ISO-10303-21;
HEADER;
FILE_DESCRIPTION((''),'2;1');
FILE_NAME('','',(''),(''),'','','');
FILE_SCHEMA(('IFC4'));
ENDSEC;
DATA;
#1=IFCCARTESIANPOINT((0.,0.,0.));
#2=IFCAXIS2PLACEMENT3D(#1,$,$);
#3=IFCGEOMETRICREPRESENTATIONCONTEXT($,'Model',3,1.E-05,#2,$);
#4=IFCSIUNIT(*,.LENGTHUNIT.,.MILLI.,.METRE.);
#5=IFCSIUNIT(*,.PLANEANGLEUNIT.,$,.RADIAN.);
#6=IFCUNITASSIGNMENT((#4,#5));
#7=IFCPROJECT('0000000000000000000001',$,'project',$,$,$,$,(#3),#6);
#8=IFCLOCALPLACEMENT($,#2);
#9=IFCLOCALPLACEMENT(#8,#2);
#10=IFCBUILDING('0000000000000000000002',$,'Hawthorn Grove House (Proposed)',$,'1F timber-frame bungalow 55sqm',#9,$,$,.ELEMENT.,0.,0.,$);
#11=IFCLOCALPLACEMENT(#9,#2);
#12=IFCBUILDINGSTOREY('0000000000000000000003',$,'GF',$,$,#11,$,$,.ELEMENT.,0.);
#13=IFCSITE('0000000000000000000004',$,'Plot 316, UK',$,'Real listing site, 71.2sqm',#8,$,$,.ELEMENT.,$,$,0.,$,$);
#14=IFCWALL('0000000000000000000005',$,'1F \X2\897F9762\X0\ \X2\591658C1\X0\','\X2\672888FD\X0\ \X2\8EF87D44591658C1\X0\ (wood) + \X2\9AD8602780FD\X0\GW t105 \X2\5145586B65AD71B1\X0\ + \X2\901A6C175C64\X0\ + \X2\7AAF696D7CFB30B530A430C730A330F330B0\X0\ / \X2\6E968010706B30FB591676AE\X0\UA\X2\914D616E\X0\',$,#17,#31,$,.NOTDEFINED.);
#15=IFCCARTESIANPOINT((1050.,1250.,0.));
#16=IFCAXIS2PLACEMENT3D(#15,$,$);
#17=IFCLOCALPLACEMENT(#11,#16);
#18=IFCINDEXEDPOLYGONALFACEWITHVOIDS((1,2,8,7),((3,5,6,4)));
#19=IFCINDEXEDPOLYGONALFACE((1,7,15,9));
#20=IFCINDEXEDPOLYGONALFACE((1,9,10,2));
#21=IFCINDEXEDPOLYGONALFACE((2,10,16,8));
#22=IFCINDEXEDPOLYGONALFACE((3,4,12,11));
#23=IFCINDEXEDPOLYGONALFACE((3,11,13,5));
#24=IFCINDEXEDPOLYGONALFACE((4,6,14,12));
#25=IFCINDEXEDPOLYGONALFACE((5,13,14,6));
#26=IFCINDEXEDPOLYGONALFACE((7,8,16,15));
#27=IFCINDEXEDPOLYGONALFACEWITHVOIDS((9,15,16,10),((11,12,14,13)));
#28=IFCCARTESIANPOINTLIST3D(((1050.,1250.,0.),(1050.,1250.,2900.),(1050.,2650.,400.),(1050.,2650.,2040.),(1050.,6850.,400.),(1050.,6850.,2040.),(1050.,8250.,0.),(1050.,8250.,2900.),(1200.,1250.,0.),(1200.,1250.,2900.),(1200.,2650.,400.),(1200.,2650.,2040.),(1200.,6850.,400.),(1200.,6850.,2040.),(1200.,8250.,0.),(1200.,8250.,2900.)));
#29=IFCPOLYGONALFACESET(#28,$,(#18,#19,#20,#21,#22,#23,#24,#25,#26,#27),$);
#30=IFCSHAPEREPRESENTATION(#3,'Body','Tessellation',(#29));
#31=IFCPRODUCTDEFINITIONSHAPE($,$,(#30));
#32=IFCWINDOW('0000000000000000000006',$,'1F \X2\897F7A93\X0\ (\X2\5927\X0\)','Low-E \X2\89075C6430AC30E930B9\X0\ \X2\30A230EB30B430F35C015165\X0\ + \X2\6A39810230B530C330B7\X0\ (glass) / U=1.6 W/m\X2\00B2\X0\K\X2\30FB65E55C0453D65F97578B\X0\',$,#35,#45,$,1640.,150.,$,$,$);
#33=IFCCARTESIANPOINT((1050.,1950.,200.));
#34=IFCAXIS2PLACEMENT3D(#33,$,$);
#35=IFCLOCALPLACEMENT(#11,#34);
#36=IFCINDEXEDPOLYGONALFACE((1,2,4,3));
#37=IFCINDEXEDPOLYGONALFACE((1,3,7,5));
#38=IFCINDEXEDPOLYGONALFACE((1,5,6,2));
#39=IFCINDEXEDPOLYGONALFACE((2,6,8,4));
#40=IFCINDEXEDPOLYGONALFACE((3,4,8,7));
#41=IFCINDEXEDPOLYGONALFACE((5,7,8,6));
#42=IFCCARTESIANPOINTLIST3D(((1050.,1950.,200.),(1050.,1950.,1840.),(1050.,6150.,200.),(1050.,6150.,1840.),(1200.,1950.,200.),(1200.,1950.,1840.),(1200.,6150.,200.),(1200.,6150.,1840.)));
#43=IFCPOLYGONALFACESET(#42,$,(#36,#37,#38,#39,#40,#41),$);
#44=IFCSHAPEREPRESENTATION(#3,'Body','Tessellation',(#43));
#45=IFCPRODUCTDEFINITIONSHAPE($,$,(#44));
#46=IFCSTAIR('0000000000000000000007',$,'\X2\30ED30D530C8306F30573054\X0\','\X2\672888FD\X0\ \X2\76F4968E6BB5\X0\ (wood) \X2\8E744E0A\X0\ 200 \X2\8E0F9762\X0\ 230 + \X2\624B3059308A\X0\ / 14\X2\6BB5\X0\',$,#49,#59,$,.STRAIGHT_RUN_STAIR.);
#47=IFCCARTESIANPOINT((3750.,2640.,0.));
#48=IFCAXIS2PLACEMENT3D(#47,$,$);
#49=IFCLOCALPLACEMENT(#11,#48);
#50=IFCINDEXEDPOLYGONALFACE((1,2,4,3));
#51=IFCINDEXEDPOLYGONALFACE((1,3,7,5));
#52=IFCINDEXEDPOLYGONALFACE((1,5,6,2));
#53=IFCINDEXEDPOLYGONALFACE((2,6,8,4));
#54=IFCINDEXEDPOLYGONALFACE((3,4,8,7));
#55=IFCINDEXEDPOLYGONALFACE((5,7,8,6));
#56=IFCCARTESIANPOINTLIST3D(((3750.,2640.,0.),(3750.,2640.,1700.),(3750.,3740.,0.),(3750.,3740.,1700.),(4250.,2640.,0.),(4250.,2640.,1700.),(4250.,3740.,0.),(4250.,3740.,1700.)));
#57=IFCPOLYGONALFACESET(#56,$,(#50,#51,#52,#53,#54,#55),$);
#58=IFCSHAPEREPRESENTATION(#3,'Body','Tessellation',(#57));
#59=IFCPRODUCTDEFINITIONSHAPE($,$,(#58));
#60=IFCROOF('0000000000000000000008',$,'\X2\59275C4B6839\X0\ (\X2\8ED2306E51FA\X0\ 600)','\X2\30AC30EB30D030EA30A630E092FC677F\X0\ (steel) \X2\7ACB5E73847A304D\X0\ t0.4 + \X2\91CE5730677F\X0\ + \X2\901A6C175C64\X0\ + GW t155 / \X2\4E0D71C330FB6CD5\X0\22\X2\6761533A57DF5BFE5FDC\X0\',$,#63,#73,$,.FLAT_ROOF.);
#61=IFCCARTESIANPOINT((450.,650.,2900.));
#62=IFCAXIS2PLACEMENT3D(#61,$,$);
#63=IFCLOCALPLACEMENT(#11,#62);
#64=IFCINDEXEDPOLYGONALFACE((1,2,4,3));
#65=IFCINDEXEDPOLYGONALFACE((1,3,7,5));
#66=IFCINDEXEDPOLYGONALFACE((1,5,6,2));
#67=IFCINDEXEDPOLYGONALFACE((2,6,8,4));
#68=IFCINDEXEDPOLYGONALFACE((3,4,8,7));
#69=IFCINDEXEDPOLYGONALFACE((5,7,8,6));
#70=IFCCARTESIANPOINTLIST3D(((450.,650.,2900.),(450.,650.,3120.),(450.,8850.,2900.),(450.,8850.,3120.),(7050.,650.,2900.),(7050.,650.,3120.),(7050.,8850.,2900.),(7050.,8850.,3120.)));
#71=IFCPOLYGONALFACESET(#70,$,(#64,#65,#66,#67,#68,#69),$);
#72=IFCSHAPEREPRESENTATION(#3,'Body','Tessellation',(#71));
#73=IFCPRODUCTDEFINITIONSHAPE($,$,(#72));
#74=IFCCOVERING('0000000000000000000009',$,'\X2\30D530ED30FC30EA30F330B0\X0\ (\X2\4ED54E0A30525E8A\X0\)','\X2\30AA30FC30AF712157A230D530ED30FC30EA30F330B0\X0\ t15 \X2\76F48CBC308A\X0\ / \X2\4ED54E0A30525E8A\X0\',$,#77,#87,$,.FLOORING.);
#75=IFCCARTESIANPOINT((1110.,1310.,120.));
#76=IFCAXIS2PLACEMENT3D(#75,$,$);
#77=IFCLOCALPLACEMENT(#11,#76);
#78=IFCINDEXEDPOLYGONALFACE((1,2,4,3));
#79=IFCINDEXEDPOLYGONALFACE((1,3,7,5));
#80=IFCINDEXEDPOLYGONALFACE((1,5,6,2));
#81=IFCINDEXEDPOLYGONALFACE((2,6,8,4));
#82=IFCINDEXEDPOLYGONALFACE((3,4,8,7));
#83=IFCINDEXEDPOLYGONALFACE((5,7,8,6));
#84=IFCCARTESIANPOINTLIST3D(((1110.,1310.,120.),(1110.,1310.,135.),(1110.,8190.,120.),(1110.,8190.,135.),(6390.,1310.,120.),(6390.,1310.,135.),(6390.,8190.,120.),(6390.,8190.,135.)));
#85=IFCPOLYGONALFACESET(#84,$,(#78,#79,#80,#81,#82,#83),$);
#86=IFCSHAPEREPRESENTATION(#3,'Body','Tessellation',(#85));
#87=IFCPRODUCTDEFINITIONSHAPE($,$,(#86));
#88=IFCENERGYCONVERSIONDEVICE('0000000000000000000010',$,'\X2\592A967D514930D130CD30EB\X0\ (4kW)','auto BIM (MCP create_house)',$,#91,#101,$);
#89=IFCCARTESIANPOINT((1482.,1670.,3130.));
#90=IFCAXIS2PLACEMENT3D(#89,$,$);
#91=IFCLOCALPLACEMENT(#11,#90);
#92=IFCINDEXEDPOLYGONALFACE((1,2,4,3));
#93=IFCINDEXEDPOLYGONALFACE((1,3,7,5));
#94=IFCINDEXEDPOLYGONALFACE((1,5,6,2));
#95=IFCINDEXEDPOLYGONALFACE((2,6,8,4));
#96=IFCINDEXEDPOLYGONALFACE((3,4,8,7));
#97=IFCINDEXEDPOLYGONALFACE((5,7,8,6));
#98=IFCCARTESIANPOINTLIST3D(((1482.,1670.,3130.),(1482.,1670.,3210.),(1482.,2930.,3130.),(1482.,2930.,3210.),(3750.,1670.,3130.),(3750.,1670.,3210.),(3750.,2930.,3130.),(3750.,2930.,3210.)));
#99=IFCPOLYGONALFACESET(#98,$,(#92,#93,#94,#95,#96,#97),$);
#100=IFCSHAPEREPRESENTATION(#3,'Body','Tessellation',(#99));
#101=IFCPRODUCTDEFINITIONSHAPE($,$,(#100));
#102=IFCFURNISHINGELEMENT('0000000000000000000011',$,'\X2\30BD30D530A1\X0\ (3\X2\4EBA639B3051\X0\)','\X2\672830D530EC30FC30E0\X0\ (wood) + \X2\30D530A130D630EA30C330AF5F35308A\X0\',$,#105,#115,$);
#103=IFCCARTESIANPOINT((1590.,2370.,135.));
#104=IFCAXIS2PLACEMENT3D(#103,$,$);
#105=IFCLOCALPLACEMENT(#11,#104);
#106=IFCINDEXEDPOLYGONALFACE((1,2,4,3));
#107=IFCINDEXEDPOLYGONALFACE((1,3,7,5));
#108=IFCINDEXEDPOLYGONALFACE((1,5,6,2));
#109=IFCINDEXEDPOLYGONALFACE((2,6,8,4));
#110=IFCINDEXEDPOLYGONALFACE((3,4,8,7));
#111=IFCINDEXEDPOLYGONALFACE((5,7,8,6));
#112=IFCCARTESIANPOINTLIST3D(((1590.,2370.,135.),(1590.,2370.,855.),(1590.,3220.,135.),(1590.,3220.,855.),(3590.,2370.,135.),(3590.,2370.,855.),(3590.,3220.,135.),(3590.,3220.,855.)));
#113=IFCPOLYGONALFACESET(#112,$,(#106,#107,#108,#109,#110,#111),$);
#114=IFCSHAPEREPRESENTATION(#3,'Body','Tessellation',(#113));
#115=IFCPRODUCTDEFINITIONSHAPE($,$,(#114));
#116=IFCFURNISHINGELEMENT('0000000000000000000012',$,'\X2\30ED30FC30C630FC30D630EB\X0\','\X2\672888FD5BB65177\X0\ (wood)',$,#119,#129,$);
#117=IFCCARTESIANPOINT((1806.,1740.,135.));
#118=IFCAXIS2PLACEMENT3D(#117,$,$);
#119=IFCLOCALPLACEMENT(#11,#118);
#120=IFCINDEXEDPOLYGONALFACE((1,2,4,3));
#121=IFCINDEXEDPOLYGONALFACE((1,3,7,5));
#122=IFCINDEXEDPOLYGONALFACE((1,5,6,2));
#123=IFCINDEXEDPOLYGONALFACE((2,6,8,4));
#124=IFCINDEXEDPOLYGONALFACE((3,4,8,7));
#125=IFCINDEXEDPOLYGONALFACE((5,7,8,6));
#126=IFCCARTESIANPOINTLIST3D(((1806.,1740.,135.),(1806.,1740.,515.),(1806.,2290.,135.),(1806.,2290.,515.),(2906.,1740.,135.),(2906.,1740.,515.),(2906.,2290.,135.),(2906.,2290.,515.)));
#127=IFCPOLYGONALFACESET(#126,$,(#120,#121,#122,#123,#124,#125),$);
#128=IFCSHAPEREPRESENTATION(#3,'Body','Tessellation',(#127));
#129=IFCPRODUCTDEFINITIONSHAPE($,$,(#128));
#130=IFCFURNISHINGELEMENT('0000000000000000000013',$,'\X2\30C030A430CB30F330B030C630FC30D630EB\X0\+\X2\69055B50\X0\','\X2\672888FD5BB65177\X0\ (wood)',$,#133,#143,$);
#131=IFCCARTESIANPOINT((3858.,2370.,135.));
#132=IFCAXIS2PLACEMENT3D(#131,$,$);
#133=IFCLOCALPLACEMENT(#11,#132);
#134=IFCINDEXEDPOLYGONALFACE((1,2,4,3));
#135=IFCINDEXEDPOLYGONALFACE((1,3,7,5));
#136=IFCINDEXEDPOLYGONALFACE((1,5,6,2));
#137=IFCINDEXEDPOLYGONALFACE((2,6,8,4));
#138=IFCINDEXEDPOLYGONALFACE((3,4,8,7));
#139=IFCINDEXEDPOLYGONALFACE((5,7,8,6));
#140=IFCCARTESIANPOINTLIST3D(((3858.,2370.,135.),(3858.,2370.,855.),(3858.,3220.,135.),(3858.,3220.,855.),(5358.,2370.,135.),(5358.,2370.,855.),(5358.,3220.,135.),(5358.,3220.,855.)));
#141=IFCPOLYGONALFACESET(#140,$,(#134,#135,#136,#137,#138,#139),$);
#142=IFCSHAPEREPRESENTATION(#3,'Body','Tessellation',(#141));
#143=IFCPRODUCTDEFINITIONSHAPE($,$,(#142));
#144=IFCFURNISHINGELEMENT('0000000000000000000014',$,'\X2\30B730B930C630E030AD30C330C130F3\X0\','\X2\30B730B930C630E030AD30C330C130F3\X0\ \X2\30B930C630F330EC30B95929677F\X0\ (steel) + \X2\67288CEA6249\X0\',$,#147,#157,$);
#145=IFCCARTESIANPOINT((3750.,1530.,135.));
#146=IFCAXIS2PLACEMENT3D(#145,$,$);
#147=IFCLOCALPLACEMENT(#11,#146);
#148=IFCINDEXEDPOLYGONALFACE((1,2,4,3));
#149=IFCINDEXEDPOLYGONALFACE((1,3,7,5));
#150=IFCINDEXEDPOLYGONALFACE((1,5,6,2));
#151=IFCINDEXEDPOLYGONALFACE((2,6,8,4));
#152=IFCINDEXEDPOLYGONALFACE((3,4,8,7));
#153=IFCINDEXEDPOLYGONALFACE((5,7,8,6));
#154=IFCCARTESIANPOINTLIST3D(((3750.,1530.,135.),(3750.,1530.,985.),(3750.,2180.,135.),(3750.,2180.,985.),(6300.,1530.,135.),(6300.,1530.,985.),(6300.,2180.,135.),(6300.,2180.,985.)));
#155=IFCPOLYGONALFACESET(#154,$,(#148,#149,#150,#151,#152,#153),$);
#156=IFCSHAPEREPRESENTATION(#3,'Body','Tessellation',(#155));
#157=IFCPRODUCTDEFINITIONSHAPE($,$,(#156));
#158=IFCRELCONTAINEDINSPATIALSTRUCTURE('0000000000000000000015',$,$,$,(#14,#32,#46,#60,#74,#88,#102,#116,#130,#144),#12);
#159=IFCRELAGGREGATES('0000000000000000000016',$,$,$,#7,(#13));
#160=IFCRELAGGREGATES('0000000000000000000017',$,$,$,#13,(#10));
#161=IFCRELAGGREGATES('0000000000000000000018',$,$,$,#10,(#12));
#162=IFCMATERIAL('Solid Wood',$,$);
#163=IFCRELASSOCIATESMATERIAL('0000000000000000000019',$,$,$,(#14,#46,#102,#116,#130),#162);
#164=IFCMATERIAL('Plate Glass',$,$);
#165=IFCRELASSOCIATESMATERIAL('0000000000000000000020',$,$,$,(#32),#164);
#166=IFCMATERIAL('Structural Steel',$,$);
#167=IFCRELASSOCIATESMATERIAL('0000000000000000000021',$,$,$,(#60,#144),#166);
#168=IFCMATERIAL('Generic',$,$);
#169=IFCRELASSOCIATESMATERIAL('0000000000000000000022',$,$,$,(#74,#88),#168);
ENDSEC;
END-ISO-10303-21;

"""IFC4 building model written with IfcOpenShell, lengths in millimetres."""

from ifc_helpers import new_model, si_unit, frame, frame_2d, origin, place, context, project, spatial, rectangle, extrude, material, element, fill, save


model = new_model("IFC4")

# Units and contexts
model_context = context("Model", 3, precision=1e-05, world=origin())
ifc_project = project(units=[si_unit("LENGTHUNIT", "METRE", prefix="MILLI"), si_unit("PLANEANGLEUNIT", "RADIAN")], contexts=[model_context])

# Site, building, storey
site_placement = place(None, origin())
site = spatial("IfcSite", under=ifc_project, at=site_placement, Name="Plot 316, UK", ObjectType="Real listing site, 71.2sqm", CompositionType="ELEMENT", RefElevation=0.0)
building_placement = place(site_placement, origin())
building = spatial("IfcBuilding", under=site, at=building_placement, Name="Hawthorn Grove House (Proposed)", ObjectType="1F timber-frame bungalow 55sqm", CompositionType="ELEMENT", ElevationOfRefHeight=0.0, ElevationOfTerrain=0.0)
storey_placement = place(building_placement, origin())
storey = spatial("IfcBuildingStorey", under=building, at=storey_placement, Name="GF", CompositionType="ELEMENT", Elevation=0.0)

# Shared definitions
ifc_material_1 = material(Name="Solid Wood")
ifc_material_2 = material(Name="Generic")

# Shared definitions
ifc_material_3 = material(Name="Plate Glass")

# Wall, opening, window
wall_1_placement = place(storey_placement, frame((1050.0, 1250.0, 0.0)))
wall_1 = element("IfcWall", 1, at=wall_1_placement, inside=storey, material=ifc_material_1, Name="1F 西面 外壁", Description="木製 軸組外壁 (wood) + 高性能GW t105 充填断熱 + 通気層 + 窯業系サイディング / 準耐火・外皮UA配慮", PredefinedType="NOTDEFINED", context=model_context, shape_type="SweptSolid", body=[
    extrude(rectangle(XDim=150.0, YDim=7000.0, at=frame_2d((75.0, 3500.0))), frame((1050.0, 1250.0, 0.0)), (0.0, 0.0, 1.0), 2900.0),
])
opening_1_placement = place(storey_placement, frame((1050.0, 1950.0, 200.0)))
opening_1 = element("IfcOpeningElement", 2, at=opening_1_placement, cuts=wall_1, PredefinedType="NOTDEFINED", context=model_context, shape_type="SweptSolid", body=[
    extrude(rectangle(XDim=150.0, YDim=4200.0, at=frame_2d((75.0, 2100.0))), frame((1050.0, 1950.0, 200.0)), (0.0, 0.0, 1.0), 1640.0),
])
window_1_placement = place(storey_placement, frame((1050.0, 1950.0, 200.0)))
window_1 = element("IfcWindow", 3, at=window_1_placement, inside=storey, material=ifc_material_3, Name="1F 西窓 (大)", Description="Low-E 複層ガラス アルゴン封入 + 樹脂サッシ (glass) / U=1.6 W/m²K・日射取得型", OverallHeight=1640.0, OverallWidth=150.0, context=model_context, shape_type="SweptSolid", body=[
    extrude(rectangle(XDim=150.0, YDim=4200.0, at=frame_2d((75.0, 2100.0))), frame((1050.0, 1950.0, 200.0)), (0.0, 0.0, 1.0), 1640.0),
])
fill(opening_1, window_1)

# Stair
stair_placement = place(storey_placement, frame((3750.0, 2640.0, 0.0)))
element("IfcStair", 4, at=stair_placement, inside=storey, material=ifc_material_1, Name="ロフトはしご", Description="木製 直階段 (wood) 蹴上 200 踏面 230 + 手すり / 14段", PredefinedType="STRAIGHT_RUN_STAIR", context=model_context, shape_type="SweptSolid", body=[
    extrude(rectangle(XDim=500.0, YDim=1100.0, at=frame_2d((250.0, 550.0))), frame((3750.0, 2640.0, 0.0)), (0.0, 0.0, 1.0), 1700.0),
])

# Roof
ifc_material_4 = material(Name="Structural Steel")
roof_placement = place(storey_placement, frame((450.0, 650.0, 2900.0)))
element("IfcRoof", 5, at=roof_placement, inside=storey, material=ifc_material_4, Name="大屋根 (軒の出 600)", Description="ガルバリウム鋼板 (steel) 立平葺き t0.4 + 野地板 + 通気層 + GW t155 / 不燃・法22条区域対応", PredefinedType="FLAT_ROOF", context=model_context, shape_type="SweptSolid", body=[
    extrude(rectangle(XDim=6600.0, YDim=8200.0, at=frame_2d((3300.0, 4100.0))), frame((450.0, 650.0, 2900.0)), (0.0, 0.0, 1.0), 220.0),
])

# Covering
covering_placement = place(storey_placement, frame((1110.0, 1310.0, 120.0)))
element("IfcCovering", 6, at=covering_placement, inside=storey, material=ifc_material_2, Name="フローリング (仕上げ床)", Description="オーク無垢フローリング t15 直貼り / 仕上げ床", PredefinedType="FLOORING", context=model_context, shape_type="SweptSolid", body=[
    extrude(rectangle(XDim=5280.0, YDim=6880.0, at=frame_2d((2640.0, 3440.0))), frame((1110.0, 1310.0, 120.0)), (0.0, 0.0, 1.0), 15.0),
])

# Energy conversion device
energy_conversion_device_placement = place(storey_placement, frame((1482.0, 1670.0, 3130.0)))
element("IfcEnergyConversionDevice", 7, at=energy_conversion_device_placement, inside=storey, material=ifc_material_2, Name="太陽光パネル (4kW)", Description="auto BIM (MCP create_house)", context=model_context, shape_type="SweptSolid", body=[
    extrude(rectangle(XDim=2268.0, YDim=1260.0, at=frame_2d((1134.0, 630.0))), frame((1482.0, 1670.0, 3130.0)), (0.0, 0.0, 1.0), 80.0),
])

# Furnishing elements
furnishing_1_placement = place(storey_placement, frame((1590.0, 2370.0, 135.0)))
element("IfcFurnishingElement", 8, at=furnishing_1_placement, inside=storey, material=ifc_material_1, Name="ソファ (3人掛け)", Description="木フレーム (wood) + ファブリック張り", context=model_context, shape_type="SweptSolid", body=[
    extrude(rectangle(XDim=2000.0, YDim=850.0, at=frame_2d((1000.0, 425.0))), frame((1590.0, 2370.0, 135.0)), (0.0, 0.0, 1.0), 720.0),
])
furnishing_2_placement = place(storey_placement, frame((1806.0, 1740.0, 135.0)))
element("IfcFurnishingElement", 9, at=furnishing_2_placement, inside=storey, material=ifc_material_1, Name="ローテーブル", Description="木製家具 (wood)", context=model_context, shape_type="SweptSolid", body=[
    extrude(rectangle(XDim=1100.0, YDim=550.0, at=frame_2d((550.0, 275.0))), frame((1806.0, 1740.0, 135.0)), (0.0, 0.0, 1.0), 380.0),
])
furnishing_3_placement = place(storey_placement, frame((3858.0, 2370.0, 135.0)))
element("IfcFurnishingElement", 10, at=furnishing_3_placement, inside=storey, material=ifc_material_1, Name="ダイニングテーブル+椅子", Description="木製家具 (wood)", context=model_context, shape_type="SweptSolid", body=[
    extrude(rectangle(XDim=1500.0, YDim=850.0, at=frame_2d((750.0, 425.0))), frame((3858.0, 2370.0, 135.0)), (0.0, 0.0, 1.0), 720.0),
])
furnishing_4_placement = place(storey_placement, frame((3750.0, 1530.0, 135.0)))
element("IfcFurnishingElement", 11, at=furnishing_4_placement, inside=storey, material=ifc_material_4, Name="システムキッチン", Description="システムキッチン ステンレス天板 (steel) + 木質扉", context=model_context, shape_type="SweptSolid", body=[
    extrude(rectangle(XDim=2550.0, YDim=650.0, at=frame_2d((1275.0, 325.0))), frame((3750.0, 1530.0, 135.0)), (0.0, 0.0, 1.0), 850.0),
])

save(model, "model.ifc")
